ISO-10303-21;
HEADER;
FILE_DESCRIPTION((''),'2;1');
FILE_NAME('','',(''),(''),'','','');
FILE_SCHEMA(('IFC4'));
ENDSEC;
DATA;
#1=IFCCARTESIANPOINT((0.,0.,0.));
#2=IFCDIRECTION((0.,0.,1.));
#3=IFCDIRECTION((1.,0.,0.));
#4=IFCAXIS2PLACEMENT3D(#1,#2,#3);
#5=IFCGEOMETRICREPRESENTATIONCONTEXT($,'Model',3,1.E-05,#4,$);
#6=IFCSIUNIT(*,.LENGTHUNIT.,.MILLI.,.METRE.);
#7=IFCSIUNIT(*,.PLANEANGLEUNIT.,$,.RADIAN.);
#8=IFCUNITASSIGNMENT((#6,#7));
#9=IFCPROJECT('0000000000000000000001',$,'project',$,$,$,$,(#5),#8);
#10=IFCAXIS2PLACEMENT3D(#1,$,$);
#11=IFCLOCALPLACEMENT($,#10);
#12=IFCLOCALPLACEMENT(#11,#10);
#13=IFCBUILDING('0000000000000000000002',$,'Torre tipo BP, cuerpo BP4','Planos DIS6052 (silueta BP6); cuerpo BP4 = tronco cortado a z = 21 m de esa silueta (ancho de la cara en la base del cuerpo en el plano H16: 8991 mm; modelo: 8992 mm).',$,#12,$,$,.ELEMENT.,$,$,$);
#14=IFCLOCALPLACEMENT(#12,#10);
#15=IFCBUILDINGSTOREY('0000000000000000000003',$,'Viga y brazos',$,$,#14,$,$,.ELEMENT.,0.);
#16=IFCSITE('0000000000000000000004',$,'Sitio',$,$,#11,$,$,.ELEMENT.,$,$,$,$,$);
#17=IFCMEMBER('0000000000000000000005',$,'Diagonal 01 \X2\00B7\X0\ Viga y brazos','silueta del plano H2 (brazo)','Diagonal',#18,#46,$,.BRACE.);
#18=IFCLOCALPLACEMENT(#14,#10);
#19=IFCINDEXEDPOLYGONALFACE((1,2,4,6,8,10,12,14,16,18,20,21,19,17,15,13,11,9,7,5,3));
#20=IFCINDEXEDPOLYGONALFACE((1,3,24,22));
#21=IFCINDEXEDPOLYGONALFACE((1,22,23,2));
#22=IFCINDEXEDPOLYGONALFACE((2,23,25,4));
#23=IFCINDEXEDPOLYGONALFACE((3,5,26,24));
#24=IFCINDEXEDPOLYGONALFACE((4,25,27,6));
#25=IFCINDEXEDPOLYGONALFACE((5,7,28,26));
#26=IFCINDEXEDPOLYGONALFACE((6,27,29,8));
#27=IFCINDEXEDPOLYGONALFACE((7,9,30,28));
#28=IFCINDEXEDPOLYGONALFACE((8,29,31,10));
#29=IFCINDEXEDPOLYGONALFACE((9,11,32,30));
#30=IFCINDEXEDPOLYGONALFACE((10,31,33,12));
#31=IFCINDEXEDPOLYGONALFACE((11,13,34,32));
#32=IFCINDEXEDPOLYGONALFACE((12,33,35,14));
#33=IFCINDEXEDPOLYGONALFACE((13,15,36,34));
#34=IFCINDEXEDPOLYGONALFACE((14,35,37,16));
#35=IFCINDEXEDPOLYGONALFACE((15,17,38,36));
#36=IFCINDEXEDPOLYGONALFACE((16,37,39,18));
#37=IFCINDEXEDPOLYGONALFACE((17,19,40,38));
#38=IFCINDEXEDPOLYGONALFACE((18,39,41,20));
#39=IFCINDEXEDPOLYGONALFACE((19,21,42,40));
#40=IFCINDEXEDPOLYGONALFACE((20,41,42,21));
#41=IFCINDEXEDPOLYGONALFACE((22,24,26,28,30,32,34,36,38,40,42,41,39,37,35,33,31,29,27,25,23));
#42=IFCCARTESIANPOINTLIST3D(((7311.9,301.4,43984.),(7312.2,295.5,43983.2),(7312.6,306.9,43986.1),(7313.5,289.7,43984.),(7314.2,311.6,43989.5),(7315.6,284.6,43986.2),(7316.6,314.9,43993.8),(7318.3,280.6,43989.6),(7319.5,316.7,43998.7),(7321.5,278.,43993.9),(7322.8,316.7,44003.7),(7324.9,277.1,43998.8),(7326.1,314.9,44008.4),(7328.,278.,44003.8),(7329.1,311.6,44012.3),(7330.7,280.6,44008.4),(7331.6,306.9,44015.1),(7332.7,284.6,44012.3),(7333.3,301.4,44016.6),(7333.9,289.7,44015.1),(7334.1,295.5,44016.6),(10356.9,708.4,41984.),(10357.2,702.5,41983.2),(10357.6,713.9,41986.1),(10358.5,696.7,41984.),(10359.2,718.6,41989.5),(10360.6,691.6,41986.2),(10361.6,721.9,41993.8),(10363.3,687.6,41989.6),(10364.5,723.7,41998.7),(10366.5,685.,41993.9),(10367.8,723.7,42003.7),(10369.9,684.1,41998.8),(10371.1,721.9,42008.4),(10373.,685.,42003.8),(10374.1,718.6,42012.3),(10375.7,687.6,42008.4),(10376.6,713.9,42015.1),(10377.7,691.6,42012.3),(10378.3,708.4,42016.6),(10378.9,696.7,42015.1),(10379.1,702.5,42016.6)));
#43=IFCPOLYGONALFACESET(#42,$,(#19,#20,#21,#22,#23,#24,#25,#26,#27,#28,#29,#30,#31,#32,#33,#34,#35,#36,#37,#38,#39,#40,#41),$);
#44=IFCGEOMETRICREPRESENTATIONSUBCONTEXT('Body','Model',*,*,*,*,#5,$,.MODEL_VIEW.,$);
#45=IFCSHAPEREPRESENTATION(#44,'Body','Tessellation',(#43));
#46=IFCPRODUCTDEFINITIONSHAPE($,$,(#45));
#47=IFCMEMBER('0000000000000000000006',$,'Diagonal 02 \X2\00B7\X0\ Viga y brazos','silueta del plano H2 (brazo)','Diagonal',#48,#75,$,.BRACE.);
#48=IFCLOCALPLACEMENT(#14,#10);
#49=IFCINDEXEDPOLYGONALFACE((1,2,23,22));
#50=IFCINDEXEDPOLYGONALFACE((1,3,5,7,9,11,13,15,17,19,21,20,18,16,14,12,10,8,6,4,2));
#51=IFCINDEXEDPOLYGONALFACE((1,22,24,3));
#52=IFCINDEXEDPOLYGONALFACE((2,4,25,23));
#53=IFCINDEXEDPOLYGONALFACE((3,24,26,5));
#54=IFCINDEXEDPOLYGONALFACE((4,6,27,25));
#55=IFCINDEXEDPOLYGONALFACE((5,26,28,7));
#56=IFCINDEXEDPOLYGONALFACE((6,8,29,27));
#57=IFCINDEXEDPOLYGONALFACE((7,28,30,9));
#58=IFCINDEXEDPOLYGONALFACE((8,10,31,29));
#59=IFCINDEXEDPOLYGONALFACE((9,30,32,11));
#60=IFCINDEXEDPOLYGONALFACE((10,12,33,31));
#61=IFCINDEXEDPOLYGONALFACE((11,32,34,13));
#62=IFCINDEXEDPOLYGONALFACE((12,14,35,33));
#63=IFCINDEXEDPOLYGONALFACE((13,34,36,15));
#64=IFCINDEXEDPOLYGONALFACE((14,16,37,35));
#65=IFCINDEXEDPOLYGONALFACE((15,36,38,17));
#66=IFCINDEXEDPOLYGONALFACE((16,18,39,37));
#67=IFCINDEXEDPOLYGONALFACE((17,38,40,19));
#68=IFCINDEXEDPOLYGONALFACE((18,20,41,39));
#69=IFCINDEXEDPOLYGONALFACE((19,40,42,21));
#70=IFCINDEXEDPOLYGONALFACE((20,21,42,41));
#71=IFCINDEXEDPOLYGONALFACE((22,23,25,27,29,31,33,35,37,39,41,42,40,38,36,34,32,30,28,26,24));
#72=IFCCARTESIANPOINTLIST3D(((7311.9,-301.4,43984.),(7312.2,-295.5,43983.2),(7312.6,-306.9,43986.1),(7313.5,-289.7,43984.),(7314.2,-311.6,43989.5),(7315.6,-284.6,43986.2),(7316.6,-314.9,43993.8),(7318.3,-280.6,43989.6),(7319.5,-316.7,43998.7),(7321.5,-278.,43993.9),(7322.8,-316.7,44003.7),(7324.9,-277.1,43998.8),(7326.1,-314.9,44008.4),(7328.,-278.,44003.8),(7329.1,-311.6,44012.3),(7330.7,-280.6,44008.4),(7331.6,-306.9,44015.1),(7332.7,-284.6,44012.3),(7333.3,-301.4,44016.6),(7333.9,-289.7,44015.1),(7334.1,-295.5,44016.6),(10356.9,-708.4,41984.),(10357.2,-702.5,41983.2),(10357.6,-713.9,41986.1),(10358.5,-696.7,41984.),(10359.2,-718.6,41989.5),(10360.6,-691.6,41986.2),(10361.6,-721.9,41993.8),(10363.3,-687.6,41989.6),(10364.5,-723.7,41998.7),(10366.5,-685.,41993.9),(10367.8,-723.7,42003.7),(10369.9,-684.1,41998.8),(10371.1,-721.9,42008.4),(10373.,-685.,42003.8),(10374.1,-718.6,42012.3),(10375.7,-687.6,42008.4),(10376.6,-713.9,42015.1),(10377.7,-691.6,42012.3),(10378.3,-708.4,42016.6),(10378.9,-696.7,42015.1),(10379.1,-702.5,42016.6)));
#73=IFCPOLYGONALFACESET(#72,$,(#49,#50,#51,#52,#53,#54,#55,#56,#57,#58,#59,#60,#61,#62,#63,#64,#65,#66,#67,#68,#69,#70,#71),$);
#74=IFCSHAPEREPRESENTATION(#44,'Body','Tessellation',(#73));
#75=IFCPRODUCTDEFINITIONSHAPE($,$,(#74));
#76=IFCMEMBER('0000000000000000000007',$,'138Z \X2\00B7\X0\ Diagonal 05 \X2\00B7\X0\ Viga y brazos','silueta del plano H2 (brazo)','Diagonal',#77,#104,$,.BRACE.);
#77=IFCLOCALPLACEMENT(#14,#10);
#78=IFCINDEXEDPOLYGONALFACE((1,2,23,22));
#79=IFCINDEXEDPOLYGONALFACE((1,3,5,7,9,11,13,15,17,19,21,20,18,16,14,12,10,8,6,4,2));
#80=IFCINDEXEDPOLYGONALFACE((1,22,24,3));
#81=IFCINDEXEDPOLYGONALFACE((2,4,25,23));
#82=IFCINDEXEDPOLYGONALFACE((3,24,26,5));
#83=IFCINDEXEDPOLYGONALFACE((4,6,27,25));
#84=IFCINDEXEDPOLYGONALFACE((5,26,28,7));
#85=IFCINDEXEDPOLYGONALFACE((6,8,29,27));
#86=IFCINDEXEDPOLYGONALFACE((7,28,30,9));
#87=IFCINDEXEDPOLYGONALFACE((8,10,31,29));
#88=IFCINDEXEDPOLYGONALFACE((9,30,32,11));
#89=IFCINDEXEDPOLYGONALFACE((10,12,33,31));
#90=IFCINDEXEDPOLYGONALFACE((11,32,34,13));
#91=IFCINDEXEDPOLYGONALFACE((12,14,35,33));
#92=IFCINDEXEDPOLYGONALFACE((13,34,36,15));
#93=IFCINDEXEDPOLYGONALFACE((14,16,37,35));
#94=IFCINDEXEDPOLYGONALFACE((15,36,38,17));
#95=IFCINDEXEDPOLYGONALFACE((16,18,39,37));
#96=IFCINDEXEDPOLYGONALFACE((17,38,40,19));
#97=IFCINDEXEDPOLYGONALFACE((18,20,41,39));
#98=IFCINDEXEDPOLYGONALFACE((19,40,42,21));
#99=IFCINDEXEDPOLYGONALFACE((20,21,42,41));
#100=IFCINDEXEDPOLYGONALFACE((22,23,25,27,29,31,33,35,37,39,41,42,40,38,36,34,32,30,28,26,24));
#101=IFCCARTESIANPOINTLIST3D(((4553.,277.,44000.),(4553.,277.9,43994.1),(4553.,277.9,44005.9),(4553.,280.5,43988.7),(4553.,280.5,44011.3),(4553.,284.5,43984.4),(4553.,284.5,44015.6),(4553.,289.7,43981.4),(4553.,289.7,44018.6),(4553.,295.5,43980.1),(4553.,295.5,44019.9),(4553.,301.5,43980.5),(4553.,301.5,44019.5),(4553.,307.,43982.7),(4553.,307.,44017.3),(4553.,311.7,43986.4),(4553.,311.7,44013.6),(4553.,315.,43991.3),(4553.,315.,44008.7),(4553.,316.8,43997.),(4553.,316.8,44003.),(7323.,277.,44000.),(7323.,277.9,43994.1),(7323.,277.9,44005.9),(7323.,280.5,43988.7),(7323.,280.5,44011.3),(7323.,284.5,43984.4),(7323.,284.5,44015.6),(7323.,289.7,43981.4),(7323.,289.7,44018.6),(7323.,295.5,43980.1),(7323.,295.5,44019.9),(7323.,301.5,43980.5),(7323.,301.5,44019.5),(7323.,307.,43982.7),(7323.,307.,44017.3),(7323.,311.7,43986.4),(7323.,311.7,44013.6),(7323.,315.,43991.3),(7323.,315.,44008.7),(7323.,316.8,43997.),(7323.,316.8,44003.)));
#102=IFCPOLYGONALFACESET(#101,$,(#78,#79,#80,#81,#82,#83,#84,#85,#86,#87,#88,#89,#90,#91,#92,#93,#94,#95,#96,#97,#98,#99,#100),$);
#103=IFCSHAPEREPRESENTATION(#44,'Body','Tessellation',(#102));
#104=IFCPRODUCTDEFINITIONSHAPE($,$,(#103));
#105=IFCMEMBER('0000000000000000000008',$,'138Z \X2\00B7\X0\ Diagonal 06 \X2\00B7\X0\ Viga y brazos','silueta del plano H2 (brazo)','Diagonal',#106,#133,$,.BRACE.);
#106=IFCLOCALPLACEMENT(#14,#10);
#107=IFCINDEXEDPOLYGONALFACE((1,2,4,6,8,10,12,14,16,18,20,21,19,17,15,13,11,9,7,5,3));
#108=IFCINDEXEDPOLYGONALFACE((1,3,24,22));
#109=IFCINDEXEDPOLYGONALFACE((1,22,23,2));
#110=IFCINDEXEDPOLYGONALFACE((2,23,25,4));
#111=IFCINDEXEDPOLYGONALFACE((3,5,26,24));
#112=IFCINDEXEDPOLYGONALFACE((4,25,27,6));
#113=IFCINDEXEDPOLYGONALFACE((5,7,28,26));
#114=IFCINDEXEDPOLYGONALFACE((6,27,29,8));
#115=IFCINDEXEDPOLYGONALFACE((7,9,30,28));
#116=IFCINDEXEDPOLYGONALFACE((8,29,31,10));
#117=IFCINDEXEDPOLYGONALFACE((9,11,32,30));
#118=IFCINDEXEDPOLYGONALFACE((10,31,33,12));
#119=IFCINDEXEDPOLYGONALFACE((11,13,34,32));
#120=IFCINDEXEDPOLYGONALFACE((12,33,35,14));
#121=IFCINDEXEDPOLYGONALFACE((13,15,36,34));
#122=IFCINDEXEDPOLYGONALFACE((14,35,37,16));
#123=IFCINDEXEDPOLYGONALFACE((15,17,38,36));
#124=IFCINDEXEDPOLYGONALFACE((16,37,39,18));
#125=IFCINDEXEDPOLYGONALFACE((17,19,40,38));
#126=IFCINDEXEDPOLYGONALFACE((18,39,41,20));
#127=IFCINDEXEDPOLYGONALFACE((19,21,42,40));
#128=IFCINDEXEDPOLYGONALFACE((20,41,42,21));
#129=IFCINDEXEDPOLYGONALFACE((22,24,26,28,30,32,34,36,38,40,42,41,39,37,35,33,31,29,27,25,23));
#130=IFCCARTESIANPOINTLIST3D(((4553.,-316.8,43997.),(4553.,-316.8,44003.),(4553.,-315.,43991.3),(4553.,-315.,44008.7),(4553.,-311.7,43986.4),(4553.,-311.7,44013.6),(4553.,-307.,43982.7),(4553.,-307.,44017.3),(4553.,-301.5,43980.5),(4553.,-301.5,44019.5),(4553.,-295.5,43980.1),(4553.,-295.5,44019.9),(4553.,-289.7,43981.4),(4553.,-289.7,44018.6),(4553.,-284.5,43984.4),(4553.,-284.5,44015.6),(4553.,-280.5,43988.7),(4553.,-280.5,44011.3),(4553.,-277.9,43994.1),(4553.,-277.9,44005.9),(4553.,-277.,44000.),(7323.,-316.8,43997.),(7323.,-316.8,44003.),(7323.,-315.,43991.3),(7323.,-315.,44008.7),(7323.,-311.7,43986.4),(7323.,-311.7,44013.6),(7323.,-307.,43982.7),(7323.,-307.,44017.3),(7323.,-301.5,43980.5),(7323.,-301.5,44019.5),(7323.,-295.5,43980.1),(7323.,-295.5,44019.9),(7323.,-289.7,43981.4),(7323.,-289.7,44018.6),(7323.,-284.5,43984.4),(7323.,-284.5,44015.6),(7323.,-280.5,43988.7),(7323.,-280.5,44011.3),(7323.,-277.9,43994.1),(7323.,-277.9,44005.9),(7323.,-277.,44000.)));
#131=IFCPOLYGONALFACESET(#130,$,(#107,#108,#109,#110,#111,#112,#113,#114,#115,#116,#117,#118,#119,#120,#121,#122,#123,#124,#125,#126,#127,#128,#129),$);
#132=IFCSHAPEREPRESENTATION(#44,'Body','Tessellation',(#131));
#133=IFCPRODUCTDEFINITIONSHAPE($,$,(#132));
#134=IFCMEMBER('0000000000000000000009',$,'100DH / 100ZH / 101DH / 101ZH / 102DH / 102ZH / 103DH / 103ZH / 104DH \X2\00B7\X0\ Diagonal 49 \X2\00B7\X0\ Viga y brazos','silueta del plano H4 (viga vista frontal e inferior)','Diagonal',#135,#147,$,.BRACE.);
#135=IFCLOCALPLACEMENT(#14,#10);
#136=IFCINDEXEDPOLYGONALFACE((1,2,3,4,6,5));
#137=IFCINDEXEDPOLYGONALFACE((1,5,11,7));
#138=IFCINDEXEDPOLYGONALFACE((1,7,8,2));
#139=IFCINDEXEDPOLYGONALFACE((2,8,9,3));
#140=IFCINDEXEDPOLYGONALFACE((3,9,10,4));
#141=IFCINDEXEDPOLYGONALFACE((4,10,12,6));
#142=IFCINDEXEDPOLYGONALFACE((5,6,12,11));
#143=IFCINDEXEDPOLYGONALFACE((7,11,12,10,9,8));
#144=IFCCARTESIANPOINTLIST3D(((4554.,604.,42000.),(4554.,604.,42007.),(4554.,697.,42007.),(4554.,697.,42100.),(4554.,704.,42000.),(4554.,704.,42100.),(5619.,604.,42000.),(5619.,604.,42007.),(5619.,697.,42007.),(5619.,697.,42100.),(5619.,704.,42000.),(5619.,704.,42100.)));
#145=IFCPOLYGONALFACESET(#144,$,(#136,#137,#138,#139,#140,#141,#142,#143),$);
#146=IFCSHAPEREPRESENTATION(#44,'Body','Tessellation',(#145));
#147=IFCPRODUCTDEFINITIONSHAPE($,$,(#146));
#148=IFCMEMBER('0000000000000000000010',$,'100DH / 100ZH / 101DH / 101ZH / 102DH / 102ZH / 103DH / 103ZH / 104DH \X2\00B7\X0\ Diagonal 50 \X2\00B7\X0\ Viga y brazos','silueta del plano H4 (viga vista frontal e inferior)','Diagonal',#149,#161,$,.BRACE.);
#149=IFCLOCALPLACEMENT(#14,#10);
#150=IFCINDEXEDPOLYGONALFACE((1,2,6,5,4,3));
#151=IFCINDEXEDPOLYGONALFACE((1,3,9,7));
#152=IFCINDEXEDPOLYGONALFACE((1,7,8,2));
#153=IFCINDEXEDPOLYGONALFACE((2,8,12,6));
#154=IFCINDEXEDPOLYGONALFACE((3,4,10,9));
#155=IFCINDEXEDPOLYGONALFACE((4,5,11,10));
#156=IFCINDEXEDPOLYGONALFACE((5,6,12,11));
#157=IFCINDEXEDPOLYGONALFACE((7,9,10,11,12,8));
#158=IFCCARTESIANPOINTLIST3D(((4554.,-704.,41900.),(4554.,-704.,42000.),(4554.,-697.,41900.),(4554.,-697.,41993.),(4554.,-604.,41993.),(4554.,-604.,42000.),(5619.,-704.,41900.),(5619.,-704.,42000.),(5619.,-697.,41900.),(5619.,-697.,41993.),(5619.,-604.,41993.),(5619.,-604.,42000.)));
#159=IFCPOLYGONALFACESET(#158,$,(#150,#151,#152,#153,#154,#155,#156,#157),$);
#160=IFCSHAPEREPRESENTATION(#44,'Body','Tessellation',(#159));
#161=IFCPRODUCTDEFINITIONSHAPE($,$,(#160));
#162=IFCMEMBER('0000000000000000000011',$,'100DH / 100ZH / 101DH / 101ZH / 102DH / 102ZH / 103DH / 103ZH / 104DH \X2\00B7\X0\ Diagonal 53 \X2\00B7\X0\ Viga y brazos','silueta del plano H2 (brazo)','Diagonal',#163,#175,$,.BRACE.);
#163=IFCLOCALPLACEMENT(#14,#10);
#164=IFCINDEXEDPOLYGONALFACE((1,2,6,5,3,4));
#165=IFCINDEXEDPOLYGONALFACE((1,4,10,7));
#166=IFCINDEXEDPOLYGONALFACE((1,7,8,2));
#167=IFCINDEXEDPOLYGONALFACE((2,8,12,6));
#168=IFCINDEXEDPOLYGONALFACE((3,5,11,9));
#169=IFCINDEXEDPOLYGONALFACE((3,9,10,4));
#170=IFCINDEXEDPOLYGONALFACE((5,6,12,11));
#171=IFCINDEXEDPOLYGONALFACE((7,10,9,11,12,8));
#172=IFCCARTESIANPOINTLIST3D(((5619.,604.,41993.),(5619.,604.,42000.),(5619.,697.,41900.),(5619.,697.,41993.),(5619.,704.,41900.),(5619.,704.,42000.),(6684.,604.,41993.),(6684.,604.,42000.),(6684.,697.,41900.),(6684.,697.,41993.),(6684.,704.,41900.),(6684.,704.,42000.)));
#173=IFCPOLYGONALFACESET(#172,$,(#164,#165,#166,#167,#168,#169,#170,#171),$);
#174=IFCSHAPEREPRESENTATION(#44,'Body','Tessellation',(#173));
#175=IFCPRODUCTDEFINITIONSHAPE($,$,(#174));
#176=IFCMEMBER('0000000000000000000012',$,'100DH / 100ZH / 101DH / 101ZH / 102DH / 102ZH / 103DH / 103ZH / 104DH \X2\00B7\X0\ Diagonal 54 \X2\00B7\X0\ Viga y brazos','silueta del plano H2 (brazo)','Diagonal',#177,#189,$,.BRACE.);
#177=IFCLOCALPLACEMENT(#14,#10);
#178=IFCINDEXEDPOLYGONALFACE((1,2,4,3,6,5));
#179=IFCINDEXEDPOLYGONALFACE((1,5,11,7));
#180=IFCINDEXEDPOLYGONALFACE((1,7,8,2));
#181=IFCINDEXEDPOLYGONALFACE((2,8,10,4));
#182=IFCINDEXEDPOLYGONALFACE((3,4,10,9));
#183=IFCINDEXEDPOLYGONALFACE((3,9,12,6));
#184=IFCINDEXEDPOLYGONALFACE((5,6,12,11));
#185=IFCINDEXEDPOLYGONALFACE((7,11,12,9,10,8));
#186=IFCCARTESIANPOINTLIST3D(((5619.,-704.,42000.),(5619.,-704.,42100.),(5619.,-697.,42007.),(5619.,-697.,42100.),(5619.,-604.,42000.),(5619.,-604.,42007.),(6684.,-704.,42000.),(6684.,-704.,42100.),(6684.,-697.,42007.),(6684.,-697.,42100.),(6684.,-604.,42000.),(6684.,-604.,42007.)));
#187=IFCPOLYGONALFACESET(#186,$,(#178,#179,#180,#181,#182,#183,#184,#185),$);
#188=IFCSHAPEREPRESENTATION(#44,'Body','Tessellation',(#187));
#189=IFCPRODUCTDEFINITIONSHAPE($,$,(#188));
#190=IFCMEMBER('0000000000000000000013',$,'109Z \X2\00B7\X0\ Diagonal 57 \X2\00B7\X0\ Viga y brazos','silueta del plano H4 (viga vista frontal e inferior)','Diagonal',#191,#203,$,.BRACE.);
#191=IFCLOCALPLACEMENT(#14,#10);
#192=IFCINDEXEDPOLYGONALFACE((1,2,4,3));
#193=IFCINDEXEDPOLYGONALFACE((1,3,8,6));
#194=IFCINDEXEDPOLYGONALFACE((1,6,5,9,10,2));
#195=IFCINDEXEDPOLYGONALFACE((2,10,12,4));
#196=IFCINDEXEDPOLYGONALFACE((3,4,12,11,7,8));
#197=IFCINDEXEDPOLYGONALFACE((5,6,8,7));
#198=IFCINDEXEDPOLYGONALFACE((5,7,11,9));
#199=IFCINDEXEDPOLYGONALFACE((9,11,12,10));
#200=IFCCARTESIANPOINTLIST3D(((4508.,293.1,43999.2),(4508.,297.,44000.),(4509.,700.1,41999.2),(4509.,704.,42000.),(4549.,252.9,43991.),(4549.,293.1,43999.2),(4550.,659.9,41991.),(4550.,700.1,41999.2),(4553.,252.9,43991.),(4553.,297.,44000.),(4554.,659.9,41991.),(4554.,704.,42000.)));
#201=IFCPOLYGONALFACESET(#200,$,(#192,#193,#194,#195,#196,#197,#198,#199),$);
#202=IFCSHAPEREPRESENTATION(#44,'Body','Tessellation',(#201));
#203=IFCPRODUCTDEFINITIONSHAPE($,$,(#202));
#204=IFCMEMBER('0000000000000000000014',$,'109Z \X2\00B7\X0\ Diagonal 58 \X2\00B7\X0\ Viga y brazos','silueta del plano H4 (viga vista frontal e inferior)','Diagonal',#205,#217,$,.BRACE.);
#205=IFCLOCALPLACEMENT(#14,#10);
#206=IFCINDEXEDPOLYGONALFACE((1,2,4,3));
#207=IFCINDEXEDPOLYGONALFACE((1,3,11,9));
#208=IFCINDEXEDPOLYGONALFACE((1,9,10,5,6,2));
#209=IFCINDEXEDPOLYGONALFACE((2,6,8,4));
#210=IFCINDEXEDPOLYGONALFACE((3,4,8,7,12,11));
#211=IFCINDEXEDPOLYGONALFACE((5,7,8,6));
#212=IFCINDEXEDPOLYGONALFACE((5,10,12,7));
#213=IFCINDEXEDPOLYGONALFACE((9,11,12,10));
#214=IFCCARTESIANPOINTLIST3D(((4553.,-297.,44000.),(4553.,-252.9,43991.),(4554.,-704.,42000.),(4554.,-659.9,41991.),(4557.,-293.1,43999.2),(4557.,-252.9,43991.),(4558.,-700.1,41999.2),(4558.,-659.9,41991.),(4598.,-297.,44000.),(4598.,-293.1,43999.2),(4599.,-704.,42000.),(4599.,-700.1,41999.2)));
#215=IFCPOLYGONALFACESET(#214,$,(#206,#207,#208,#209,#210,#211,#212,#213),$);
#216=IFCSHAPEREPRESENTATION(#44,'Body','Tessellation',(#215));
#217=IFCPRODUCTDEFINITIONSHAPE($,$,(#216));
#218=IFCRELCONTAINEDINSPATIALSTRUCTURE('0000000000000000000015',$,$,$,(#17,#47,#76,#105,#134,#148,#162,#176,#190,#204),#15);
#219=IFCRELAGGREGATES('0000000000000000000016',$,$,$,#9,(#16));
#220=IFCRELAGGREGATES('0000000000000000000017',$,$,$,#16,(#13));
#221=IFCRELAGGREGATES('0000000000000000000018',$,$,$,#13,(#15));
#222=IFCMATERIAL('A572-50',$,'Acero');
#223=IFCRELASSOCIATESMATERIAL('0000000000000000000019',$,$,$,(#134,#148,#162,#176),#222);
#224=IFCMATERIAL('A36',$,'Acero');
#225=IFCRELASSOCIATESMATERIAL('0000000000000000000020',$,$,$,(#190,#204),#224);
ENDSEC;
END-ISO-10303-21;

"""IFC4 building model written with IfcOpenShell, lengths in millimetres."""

from ifc_helpers import new_model, si_unit, frame, frame_2d, origin, origin_with_axes, place, context, subcontext, project, spatial, circle, l_section, extrude, material, element, save


model = new_model("IFC4")

# Units and contexts
model_context = context("Model", 3, precision=1e-05, world=origin_with_axes())
body_context = subcontext(model_context, "Body", "Model", "MODEL_VIEW")
ifc_project = project(units=[si_unit("LENGTHUNIT", "METRE", prefix="MILLI"), si_unit("PLANEANGLEUNIT", "RADIAN")], contexts=[model_context])

# Site, building, storey
site_placement = place(None, origin())
site = spatial("IfcSite", under=ifc_project, at=site_placement, Name="Sitio", CompositionType="ELEMENT")
building_placement = place(site_placement, origin())
building = spatial("IfcBuilding", under=site, at=building_placement, Name="Torre tipo BP, cuerpo BP4", Description="Planos DIS6052 (silueta BP6); cuerpo BP4 = tronco cortado a z = 21 m de esa silueta (ancho de la cara en la base del cuerpo en el plano H16: 8991 mm; modelo: 8992 mm).", CompositionType="ELEMENT")
storey_placement = place(building_placement, origin())
storey = spatial("IfcBuildingStorey", under=building, at=storey_placement, Name="Viga y brazos", CompositionType="ELEMENT", Elevation=0.0)

# Members
for number, where, z_axis, x_axis, name in (
    (1, (7323.0, 297.0, 44000.0), (0.830664, 0.111028, -0.545592), (0.092801, -0.993817, -0.060953), "Diagonal 01 · Viga y brazos"),
    (2, (7323.0, -297.0, 44000.0), (0.830664, -0.111028, -0.545592), (0.092801, 0.993817, -0.060953), "Diagonal 02 · Viga y brazos"),
):
    element("IfcMember", number, at=place(storey_placement, frame(where, z_axis=z_axis, x_axis=x_axis)), inside=storey, Name=name, Description="silueta del plano H2 (brazo)", ObjectType="Diagonal", PredefinedType="BRACE", context=body_context, shape_type="SweptSolid", body=[
        extrude(circle(Radius=20.0), None, (0.0, 0.0, 1.0), 3665.7),
    ])
for number, where, z_axis, x_axis, name in (
    (3, (7323.0, 297.0, 44000.0), (-1.0, 0.0, 0.0), (0.0, -1.0, 0.0), "138Z · Diagonal 05 · Viga y brazos"),
    (4, (7323.0, -297.0, 44000.0), (-1.0, 0.0, 0.0), (0.0, 1.0, 0.0), "138Z · Diagonal 06 · Viga y brazos"),
):
    element("IfcMember", number, at=place(storey_placement, frame(where, z_axis=z_axis, x_axis=x_axis)), inside=storey, Name=name, Description="silueta del plano H2 (brazo)", ObjectType="Diagonal", PredefinedType="BRACE", context=body_context, shape_type="SweptSolid", body=[
        extrude(circle(Radius=20.0), None, (0.0, 0.0, 1.0), 2770.0),
    ])
ifc_material_1 = material(Name="A572-50", Category="Acero")
for number, where, z_axis, x_axis, name, description in (
    (5, (5619.0, 704.0, 42000.0), (-1.0, 0.0, 0.0), (0.0, -1.0, 0.0), "100DH / 100ZH / 101DH / 101ZH / 102DH / 102ZH / 103DH / 103ZH / 104DH · Diagonal 49 · Viga y brazos", "silueta del plano H4 (viga vista frontal e inferior)"),
    (6, (5619.0, -704.0, 42000.0), (-1.0, 0.0, 0.0), (0.0, 1.0, 0.0), "100DH / 100ZH / 101DH / 101ZH / 102DH / 102ZH / 103DH / 103ZH / 104DH · Diagonal 50 · Viga y brazos", "silueta del plano H4 (viga vista frontal e inferior)"),
    (7, (5619.0, 704.0, 42000.0), (1.0, 0.0, 0.0), (0.0, -1.0, 0.0), "100DH / 100ZH / 101DH / 101ZH / 102DH / 102ZH / 103DH / 103ZH / 104DH · Diagonal 53 · Viga y brazos", "silueta del plano H2 (brazo)"),
    (8, (5619.0, -704.0, 42000.0), (1.0, 0.0, 0.0), (0.0, 1.0, 0.0), "100DH / 100ZH / 101DH / 101ZH / 102DH / 102ZH / 103DH / 103ZH / 104DH · Diagonal 54 · Viga y brazos", "silueta del plano H2 (brazo)"),
):
    element("IfcMember", number, at=place(storey_placement, frame(where, z_axis=z_axis, x_axis=x_axis)), inside=storey, material=ifc_material_1, Name=name, Description=description, ObjectType="Diagonal", PredefinedType="BRACE", context=body_context, shape_type="SweptSolid", body=[
        extrude(l_section(Depth=100.0, Width=100.0, Thickness=7.0, at=frame_2d((50.0, 50.0))), None, (0.0, 0.0, 1.0), 1065.0),
    ])
ifc_material_2 = material(Name="A36", Category="Acero")
for number, where, z_axis, x_axis, name in (
    (9, (4553.0, 297.0, 44000.0), (0.00049, 0.199413, -0.979915), (0.0001, -0.979916, -0.199413), "109Z · Diagonal 57 · Viga y brazos"),
    (10, (4553.0, -297.0, 44000.0), (0.00049, -0.199413, -0.979915), (0.0001, 0.979916, -0.199413), "109Z · Diagonal 58 · Viga y brazos"),
):
    element("IfcMember", number, at=place(storey_placement, frame(where, z_axis=z_axis, x_axis=x_axis)), inside=storey, material=ifc_material_2, Name=name, Description="silueta del plano H4 (viga vista frontal e inferior)", ObjectType="Diagonal", PredefinedType="BRACE", context=body_context, shape_type="SweptSolid", body=[
        extrude(l_section(Depth=45.0, Width=45.0, Thickness=4.0, at=frame_2d((22.5, 22.5))), None, (0.0, 0.0, 1.0), 2041.0),
    ])

save(model, "model.ifc")
